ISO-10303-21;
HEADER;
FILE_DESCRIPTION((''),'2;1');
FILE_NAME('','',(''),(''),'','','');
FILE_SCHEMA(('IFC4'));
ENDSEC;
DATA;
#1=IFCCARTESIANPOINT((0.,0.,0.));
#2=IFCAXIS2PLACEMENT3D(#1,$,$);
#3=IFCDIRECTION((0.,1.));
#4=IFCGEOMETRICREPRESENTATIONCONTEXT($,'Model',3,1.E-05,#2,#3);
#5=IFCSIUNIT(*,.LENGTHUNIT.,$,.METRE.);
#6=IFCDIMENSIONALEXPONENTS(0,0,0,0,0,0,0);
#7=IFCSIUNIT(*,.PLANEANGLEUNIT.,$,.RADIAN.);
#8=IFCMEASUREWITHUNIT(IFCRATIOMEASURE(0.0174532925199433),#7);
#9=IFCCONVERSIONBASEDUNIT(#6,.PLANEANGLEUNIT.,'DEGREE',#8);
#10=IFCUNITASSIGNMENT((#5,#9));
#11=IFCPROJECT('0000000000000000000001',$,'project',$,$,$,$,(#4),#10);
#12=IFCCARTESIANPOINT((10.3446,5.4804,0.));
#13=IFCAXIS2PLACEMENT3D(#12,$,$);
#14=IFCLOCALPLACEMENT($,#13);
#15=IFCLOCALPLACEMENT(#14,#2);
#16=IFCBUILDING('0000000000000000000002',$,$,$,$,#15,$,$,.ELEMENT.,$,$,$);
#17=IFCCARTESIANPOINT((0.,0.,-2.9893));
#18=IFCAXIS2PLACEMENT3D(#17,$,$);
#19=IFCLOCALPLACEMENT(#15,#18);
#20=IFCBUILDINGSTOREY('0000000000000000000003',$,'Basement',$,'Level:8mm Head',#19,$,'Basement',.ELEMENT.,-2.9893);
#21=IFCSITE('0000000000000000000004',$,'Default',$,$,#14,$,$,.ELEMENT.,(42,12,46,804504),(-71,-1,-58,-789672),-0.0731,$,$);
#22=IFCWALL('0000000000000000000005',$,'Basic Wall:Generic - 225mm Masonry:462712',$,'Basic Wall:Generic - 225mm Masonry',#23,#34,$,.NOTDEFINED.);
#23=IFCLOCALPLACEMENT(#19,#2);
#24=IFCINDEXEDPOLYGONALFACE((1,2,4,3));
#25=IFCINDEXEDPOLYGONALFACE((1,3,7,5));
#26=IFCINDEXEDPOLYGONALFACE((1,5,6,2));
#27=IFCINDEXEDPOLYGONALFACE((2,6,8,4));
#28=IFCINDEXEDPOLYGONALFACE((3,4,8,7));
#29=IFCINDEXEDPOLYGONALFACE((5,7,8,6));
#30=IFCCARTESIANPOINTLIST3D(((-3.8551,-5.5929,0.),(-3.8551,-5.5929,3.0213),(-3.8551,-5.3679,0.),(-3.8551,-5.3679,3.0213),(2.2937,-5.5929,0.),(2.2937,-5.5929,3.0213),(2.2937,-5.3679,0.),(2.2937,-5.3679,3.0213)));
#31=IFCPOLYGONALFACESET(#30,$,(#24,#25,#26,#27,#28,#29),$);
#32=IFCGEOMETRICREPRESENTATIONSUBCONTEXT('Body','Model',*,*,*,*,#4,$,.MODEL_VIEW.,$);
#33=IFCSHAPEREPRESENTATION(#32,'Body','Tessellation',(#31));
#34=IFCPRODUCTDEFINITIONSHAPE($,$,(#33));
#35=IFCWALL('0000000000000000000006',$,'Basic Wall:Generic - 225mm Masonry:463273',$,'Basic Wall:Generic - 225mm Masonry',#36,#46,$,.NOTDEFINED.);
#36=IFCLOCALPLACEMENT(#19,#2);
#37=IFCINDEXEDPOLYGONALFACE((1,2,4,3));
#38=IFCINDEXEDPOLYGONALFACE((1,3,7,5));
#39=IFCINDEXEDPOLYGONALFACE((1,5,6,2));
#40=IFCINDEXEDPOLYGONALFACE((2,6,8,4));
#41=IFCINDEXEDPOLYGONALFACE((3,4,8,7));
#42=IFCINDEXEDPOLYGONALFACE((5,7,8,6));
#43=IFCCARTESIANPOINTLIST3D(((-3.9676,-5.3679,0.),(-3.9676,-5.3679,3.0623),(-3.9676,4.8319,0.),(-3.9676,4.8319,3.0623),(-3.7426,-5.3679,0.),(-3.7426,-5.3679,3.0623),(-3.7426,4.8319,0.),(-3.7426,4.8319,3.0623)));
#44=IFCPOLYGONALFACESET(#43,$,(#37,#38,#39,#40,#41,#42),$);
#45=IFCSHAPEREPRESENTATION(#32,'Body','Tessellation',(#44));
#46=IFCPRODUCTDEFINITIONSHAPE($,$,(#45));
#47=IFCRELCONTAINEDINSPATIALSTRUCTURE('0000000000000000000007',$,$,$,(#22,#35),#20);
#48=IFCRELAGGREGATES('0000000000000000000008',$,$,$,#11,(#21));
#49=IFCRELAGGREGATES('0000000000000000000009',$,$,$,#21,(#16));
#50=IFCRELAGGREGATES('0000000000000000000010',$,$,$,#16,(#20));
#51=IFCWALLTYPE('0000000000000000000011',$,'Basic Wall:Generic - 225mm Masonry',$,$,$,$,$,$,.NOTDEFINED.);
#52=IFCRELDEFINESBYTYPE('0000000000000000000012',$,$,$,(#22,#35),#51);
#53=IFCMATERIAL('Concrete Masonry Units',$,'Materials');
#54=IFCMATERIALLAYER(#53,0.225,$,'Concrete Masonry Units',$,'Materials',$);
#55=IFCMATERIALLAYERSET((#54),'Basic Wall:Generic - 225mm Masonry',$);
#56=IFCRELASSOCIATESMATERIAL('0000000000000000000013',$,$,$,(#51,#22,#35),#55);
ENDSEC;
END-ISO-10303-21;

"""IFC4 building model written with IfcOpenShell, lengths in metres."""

from ifc_helpers import new_model, entity, si_unit, converted_unit, direction, frame, frame_2d, origin, place, context, subcontext, project, spatial, polyline, rectangle, extrude, clip, bounded_halfspace, material, layer, layer_set, layer_usage, type_object, element, save


model = new_model("IFC4")

# Units and contexts
model_context = context("Model", 3, precision=1e-05, world=origin(), true_north=direction((0.0, 1.0)))
body_context = subcontext(model_context, "Body", "Model", "MODEL_VIEW")
ifc_project = project(units=[si_unit("LENGTHUNIT", "METRE"), converted_unit("PLANEANGLEUNIT", "DEGREE", entity("IfcRatioMeasure", 0.0174532925199433), si_unit("PLANEANGLEUNIT", "RADIAN"), dimensions=[0, 0, 0, 0, 0, 0, 0])], contexts=[model_context])

# Site, building, storey
site_placement = place(None, frame((10.3446, 5.4804, 0.0)))
site = spatial("IfcSite", under=ifc_project, at=site_placement, Name="Default", CompositionType="ELEMENT", RefLatitude=(42, 12, 46, 804504), RefLongitude=(-71, -1, -58, -789672), RefElevation=-0.0731)
building_placement = place(site_placement, origin())
building = spatial("IfcBuilding", under=site, at=building_placement, CompositionType="ELEMENT")
storey_placement = place(building_placement, frame((0.0, 0.0, -2.9893)))
storey = spatial("IfcBuildingStorey", under=building, at=storey_placement, Name="Basement", ObjectType="Level:8mm Head", LongName="Basement", CompositionType="ELEMENT", Elevation=-2.9893)

# Walls
ifc_material_1 = material(Name="Concrete Masonry Units", Category="Materials")
ifc_layer_1 = layer(ifc_material_1, 0.225, Name="Concrete Masonry Units", Category="Materials")
ifc_layer_set_1 = layer_set([ifc_layer_1], Name="Basic Wall:Generic - 225mm Masonry")
wall_type = type_object("IfcWallType", Name="Basic Wall:Generic - 225mm Masonry", PredefinedType="NOTDEFINED", material=ifc_layer_set_1)
ifc_layer_usage_1 = layer_usage(ifc_layer_set_1, "AXIS2", "NEGATIVE", 0.1125)
wall_1_placement = place(storey_placement, frame((2.2937, -5.4804, 0.0), z_axis=(0.0, 0.0, 1.0), x_axis=(-1.0, 0.0, 0.0)))
element("IfcWall", 1, at=wall_1_placement, inside=storey, type_object=wall_type, material=ifc_layer_usage_1, Name="Basic Wall:Generic - 225mm Masonry:462712", ObjectType="Basic Wall:Generic - 225mm Masonry", PredefinedType="NOTDEFINED", context=body_context, shape_type="Clipping", body=[
    clip(extrude(rectangle(XDim=6.1488, YDim=0.225, at=frame_2d((3.0744, 0.0), x_axis=(-1.0, 0.0))), origin(), (0.0, 0.0, 1.0), 3.0213), bounded_halfspace(frame((0.0, -0.1125, 3.0213), z_axis=(0.0, 0.0, -1.0), x_axis=(0.0, -1.0, 0.0)), True, frame((0.0, -0.1125, 3.0213)), polyline([(0.0, 0.0), (0.1125, 0.0), (5.9627, 0.0), (5.9627, 0.1125), (0.0, 0.1125), (0.0, 0.0)]))),
])
ifc_layer_usage_2 = layer_usage(ifc_layer_set_1, "AXIS2", "NEGATIVE", 0.1125)
wall_2_placement = place(storey_placement, frame((-3.8551, 4.8319, 0.0), z_axis=(0.0, 0.0, 1.0), x_axis=(0.0, -1.0, 0.0)))
element("IfcWall", 2, at=wall_2_placement, inside=storey, type_object=wall_type, material=ifc_layer_usage_2, Name="Basic Wall:Generic - 225mm Masonry:463273", ObjectType="Basic Wall:Generic - 225mm Masonry", PredefinedType="NOTDEFINED", context=body_context, shape_type="SweptSolid", body=[
    extrude(rectangle(XDim=10.1998, YDim=0.225, at=frame_2d((5.0999, 0.0), x_axis=(-1.0, 0.0))), origin(), (0.0, 0.0, 1.0), 3.0623),
])

save(model, "model.ifc")
